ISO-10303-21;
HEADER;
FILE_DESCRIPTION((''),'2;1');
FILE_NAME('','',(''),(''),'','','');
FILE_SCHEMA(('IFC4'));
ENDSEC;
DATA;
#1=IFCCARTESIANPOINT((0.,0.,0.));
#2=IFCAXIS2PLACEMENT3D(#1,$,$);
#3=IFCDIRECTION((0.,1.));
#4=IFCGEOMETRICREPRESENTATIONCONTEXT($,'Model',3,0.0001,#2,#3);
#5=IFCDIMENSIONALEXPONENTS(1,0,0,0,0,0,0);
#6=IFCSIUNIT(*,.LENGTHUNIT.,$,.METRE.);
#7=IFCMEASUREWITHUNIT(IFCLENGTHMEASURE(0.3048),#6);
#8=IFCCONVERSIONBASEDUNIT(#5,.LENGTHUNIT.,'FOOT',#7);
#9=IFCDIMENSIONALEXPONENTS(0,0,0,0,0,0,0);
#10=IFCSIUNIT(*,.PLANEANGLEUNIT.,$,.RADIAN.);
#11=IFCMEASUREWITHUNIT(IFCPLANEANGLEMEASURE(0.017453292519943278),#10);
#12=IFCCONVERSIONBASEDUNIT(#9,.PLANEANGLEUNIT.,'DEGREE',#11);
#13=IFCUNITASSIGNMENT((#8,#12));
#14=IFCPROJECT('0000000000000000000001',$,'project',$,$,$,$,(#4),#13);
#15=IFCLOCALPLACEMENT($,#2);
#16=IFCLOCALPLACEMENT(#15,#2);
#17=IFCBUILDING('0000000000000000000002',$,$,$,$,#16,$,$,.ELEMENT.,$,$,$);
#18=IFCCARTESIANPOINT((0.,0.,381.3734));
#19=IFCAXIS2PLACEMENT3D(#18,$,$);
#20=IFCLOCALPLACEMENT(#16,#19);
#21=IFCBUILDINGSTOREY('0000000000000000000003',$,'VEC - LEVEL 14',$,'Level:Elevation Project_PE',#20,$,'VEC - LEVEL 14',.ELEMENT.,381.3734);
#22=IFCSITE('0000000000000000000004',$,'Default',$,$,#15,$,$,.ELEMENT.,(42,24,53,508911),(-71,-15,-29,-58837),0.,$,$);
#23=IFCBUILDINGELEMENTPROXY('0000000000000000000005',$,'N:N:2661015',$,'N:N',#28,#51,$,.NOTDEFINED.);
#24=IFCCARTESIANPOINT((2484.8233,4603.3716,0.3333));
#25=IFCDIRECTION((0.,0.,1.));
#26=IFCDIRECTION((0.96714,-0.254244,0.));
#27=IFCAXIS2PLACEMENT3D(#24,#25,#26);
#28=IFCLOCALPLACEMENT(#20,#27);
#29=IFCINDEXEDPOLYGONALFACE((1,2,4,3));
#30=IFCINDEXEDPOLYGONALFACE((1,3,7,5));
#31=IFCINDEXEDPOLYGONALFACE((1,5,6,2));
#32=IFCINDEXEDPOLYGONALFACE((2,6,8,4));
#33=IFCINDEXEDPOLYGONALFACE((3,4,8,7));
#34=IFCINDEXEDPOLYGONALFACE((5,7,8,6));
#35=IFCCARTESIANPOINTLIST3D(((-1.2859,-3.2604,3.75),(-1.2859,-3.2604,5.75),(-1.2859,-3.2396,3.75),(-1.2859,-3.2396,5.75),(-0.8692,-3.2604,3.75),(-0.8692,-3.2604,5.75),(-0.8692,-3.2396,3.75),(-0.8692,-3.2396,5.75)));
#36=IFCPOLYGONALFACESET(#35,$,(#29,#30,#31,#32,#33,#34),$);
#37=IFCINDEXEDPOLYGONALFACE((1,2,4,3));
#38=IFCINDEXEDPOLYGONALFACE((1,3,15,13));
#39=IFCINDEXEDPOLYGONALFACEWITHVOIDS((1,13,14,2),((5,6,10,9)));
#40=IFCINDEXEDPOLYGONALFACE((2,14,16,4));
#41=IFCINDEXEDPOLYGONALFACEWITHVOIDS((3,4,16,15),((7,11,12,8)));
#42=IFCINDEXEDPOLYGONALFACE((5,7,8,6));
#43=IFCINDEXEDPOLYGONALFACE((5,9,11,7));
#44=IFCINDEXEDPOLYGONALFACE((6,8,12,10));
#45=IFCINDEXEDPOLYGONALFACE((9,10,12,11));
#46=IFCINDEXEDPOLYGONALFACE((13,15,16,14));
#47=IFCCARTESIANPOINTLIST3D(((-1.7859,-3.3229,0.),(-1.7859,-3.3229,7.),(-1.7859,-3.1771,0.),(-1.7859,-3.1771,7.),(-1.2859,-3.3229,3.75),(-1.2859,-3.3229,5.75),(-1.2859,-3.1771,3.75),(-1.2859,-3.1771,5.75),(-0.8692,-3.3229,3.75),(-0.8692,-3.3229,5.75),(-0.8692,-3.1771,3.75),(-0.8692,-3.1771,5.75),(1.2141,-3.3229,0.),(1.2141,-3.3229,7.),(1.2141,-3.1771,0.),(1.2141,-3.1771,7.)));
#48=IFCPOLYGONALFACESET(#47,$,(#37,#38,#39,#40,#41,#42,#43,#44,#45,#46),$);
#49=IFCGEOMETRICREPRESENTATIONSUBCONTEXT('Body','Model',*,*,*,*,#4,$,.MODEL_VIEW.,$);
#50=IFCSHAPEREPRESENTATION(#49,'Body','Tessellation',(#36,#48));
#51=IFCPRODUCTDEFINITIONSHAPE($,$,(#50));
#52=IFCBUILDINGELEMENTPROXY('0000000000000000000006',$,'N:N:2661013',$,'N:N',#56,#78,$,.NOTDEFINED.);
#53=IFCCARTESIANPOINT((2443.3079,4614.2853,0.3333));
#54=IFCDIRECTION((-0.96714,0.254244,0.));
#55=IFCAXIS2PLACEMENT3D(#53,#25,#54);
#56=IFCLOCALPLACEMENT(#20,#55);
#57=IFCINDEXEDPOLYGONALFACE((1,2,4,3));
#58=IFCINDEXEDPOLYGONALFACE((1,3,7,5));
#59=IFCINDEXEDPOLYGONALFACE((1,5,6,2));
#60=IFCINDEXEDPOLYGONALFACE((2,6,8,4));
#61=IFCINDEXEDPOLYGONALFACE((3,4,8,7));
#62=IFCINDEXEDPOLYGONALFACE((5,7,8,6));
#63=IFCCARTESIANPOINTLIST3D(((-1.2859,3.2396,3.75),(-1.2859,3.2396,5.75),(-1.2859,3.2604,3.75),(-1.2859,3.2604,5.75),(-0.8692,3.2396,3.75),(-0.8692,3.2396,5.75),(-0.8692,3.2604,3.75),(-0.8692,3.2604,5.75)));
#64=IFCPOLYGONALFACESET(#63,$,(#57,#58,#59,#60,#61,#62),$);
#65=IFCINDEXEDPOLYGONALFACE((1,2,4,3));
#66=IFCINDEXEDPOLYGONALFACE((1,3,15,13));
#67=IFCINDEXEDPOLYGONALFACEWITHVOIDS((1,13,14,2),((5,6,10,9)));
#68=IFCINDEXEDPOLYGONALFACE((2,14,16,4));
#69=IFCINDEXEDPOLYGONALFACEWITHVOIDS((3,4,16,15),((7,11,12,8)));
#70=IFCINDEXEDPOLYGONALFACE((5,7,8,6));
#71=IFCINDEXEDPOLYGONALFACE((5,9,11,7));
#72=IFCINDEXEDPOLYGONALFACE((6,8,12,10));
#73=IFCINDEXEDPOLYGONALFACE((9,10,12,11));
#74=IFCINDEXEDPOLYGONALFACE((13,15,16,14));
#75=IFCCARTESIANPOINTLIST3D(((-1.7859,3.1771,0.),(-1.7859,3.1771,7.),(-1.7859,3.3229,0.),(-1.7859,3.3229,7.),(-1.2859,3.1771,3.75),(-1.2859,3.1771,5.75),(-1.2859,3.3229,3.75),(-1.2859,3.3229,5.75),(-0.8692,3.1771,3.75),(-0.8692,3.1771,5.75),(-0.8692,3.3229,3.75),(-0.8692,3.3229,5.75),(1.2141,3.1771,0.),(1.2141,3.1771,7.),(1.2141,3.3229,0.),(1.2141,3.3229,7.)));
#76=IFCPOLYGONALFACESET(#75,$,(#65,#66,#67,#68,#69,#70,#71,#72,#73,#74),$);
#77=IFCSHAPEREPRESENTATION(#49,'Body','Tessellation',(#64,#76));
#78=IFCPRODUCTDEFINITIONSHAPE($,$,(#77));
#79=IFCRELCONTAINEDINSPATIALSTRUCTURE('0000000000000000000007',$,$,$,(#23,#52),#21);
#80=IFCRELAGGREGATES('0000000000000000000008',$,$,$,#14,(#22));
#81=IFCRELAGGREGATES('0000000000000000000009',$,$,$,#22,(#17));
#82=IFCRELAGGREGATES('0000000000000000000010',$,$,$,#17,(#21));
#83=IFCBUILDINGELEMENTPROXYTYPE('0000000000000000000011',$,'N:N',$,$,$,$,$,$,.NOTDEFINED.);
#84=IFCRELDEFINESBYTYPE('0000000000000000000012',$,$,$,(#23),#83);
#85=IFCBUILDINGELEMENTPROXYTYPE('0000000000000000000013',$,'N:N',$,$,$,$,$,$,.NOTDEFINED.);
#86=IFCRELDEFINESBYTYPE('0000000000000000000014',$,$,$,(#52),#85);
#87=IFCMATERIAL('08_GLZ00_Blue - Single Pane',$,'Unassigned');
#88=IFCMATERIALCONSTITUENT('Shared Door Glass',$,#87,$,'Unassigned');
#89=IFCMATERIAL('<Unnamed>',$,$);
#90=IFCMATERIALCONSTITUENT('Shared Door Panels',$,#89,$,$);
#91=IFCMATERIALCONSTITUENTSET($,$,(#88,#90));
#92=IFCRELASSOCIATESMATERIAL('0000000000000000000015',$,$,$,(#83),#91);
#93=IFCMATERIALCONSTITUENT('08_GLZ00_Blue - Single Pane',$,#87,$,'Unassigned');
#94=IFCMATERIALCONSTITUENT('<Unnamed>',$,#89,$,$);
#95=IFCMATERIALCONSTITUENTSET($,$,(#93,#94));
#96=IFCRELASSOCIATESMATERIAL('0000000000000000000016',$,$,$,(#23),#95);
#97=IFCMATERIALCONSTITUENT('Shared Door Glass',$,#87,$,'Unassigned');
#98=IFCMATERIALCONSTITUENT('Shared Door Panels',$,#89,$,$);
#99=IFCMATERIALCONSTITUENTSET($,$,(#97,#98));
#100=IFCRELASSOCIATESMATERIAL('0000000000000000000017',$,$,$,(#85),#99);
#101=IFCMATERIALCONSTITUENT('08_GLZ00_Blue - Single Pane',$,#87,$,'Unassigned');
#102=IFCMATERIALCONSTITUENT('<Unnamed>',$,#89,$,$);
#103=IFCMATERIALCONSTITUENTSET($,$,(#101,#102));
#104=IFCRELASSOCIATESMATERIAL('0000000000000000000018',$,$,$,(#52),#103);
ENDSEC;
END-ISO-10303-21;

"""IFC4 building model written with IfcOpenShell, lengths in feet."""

from ifc_helpers import new_model, entity, si_unit, converted_unit, direction, frame, origin, place, context, subcontext, project, spatial, indexed_curve, outline, extrude, source, transform, mapped, material, constituent, constituent_set, type_object, type_shapes, element, save


model = new_model("IFC4")

# Units and contexts
model_context = context("Model", 3, precision=0.0001, world=origin(), true_north=direction((0.0, 1.0)))
body_context = subcontext(model_context, "Body", "Model", "MODEL_VIEW")
ifc_project = project(units=[converted_unit("LENGTHUNIT", "FOOT", entity("IfcLengthMeasure", 0.3048), si_unit("LENGTHUNIT", "METRE"), dimensions=[1, 0, 0, 0, 0, 0, 0]), converted_unit("PLANEANGLEUNIT", "DEGREE", entity("IfcPlaneAngleMeasure", 0.017453292519943278), si_unit("PLANEANGLEUNIT", "RADIAN"), dimensions=[0, 0, 0, 0, 0, 0, 0])], contexts=[model_context])

# Site, building, storey
site_placement = place(None, origin())
site = spatial("IfcSite", under=ifc_project, at=site_placement, Name="Default", CompositionType="ELEMENT", RefLatitude=(42, 24, 53, 508911), RefLongitude=(-71, -15, -29, -58837), RefElevation=0.0)
building_placement = place(site_placement, origin())
building = spatial("IfcBuilding", under=site, at=building_placement, CompositionType="ELEMENT")
storey_placement = place(building_placement, frame((0.0, 0.0, 381.3734)))
storey = spatial("IfcBuildingStorey", under=building, at=storey_placement, Name="VEC - LEVEL 14", ObjectType="Level:Elevation Project_PE", LongName="VEC - LEVEL 14", CompositionType="ELEMENT", Elevation=381.3734)

# Shared definitions
ifc_material_1 = material(Name="<Unnamed>")

# Building element proxies
ifc_material_2 = material(Name="08_GLZ00_Blue - Single Pane", Category="Unassigned")
ifc_constituent_1 = constituent(ifc_material_2, Name="08_GLZ00_Blue - Single Pane", Category="Unassigned")
ifc_constituent_2 = constituent(ifc_material_1, Name="<Unnamed>")
ifc_constituent_set_1 = constituent_set(constituents=[ifc_constituent_1, ifc_constituent_2])
ifc_constituent_3 = constituent(ifc_material_2, Name="Shared Door Glass", Category="Unassigned")
ifc_constituent_4 = constituent(ifc_material_1, Name="Shared Door Panels")
ifc_constituent_set_2 = constituent_set(constituents=[ifc_constituent_3, ifc_constituent_4])
building_element_proxy_type_1 = type_object("IfcBuildingElementProxyType", Name="N:N", PredefinedType="NOTDEFINED", material=ifc_constituent_set_2)
shared_shape_1 = source(origin(), body_context, "Body", "SweptSolid", [
    extrude(outline(indexed_curve([(-0.2083, -0.0104), (0.2083, -0.0104), (0.2083, 0.0104), (-0.2083, 0.0104), (-0.2083, -0.0104)], self_intersect=False)), frame((-1.0775, -3.25, 3.75), z_axis=(0.0, 0.0, 1.0), x_axis=(-1.0, 0.0, 0.0)), (0.0, 0.0, 1.0), 2.0),
    extrude(outline(indexed_curve([(-3.5, -1.5), (3.5, -1.5), (3.5, 1.5), (-3.5, 1.5), (-3.5, -1.5)], self_intersect=False), holes=[indexed_curve([(-2.25, 0.5833), (-2.25, 1.0), (-0.25, 1.0), (-0.25, 0.5833), (-2.25, 0.5833)], self_intersect=False)]), frame((-0.2859, -3.3229, 3.5), z_axis=(0.0, 1.0, 0.0), x_axis=(0.0, 0.0, -1.0)), (0.0, 0.0, 1.0), 0.1458),
])
type_shapes(building_element_proxy_type_1, [shared_shape_1])
proxy_1_placement = place(storey_placement, frame((2484.8233, 4603.3716, 0.3333), z_axis=(0.0, 0.0, 1.0), x_axis=(0.96714, -0.254244, 0.0)))
element("IfcBuildingElementProxy", 1, at=proxy_1_placement, inside=storey, type_object=building_element_proxy_type_1, material=ifc_constituent_set_1, Name="N:N:2661015", ObjectType="N:N", PredefinedType="NOTDEFINED", context=body_context, shape_type="MappedRepresentation", body=[
    mapped(shared_shape_1, transform((0.0, 0.0, 0.0), scale=1.0)),
])
ifc_constituent_5 = constituent(ifc_material_2, Name="08_GLZ00_Blue - Single Pane", Category="Unassigned")
ifc_constituent_6 = constituent(ifc_material_1, Name="<Unnamed>")
ifc_constituent_set_3 = constituent_set(constituents=[ifc_constituent_5, ifc_constituent_6])
ifc_constituent_7 = constituent(ifc_material_2, Name="Shared Door Glass", Category="Unassigned")
ifc_constituent_8 = constituent(ifc_material_1, Name="Shared Door Panels")
ifc_constituent_set_4 = constituent_set(constituents=[ifc_constituent_7, ifc_constituent_8])
building_element_proxy_type_2 = type_object("IfcBuildingElementProxyType", Name="N:N", PredefinedType="NOTDEFINED", material=ifc_constituent_set_4)
shared_shape_2 = source(origin(), body_context, "Body", "SweptSolid", [
    extrude(outline(indexed_curve([(-0.0104, -0.2083), (0.0104, -0.2083), (0.0104, 0.2083), (-0.0104, 0.2083), (-0.0104, -0.2083)], self_intersect=False)), frame((-1.0775, 3.25, 3.75), z_axis=(0.0, 0.0, 1.0), x_axis=(0.0, 1.0, 0.0)), (0.0, 0.0, 1.0), 2.0),
    extrude(outline(indexed_curve([(-3.5, -1.5), (3.5, -1.5), (3.5, 1.5), (-3.5, 1.5), (-3.5, -1.5)], self_intersect=False), holes=[indexed_curve([(-2.25, 0.5833), (-2.25, 1.0), (-0.25, 1.0), (-0.25, 0.5833), (-2.25, 0.5833)], self_intersect=False)]), frame((-0.2859, 3.1771, 3.5), z_axis=(0.0, 1.0, 0.0), x_axis=(0.0, 0.0, -1.0)), (0.0, 0.0, 1.0), 0.1458),
])
type_shapes(building_element_proxy_type_2, [shared_shape_2])
proxy_2_placement = place(storey_placement, frame((2443.3079, 4614.2853, 0.3333), z_axis=(0.0, 0.0, 1.0), x_axis=(-0.96714, 0.254244, 0.0)))
element("IfcBuildingElementProxy", 2, at=proxy_2_placement, inside=storey, type_object=building_element_proxy_type_2, material=ifc_constituent_set_3, Name="N:N:2661013", ObjectType="N:N", PredefinedType="NOTDEFINED", context=body_context, shape_type="MappedRepresentation", body=[
    mapped(shared_shape_2, transform((0.0, 0.0, 0.0), scale=1.0)),
])

save(model, "model.ifc")
